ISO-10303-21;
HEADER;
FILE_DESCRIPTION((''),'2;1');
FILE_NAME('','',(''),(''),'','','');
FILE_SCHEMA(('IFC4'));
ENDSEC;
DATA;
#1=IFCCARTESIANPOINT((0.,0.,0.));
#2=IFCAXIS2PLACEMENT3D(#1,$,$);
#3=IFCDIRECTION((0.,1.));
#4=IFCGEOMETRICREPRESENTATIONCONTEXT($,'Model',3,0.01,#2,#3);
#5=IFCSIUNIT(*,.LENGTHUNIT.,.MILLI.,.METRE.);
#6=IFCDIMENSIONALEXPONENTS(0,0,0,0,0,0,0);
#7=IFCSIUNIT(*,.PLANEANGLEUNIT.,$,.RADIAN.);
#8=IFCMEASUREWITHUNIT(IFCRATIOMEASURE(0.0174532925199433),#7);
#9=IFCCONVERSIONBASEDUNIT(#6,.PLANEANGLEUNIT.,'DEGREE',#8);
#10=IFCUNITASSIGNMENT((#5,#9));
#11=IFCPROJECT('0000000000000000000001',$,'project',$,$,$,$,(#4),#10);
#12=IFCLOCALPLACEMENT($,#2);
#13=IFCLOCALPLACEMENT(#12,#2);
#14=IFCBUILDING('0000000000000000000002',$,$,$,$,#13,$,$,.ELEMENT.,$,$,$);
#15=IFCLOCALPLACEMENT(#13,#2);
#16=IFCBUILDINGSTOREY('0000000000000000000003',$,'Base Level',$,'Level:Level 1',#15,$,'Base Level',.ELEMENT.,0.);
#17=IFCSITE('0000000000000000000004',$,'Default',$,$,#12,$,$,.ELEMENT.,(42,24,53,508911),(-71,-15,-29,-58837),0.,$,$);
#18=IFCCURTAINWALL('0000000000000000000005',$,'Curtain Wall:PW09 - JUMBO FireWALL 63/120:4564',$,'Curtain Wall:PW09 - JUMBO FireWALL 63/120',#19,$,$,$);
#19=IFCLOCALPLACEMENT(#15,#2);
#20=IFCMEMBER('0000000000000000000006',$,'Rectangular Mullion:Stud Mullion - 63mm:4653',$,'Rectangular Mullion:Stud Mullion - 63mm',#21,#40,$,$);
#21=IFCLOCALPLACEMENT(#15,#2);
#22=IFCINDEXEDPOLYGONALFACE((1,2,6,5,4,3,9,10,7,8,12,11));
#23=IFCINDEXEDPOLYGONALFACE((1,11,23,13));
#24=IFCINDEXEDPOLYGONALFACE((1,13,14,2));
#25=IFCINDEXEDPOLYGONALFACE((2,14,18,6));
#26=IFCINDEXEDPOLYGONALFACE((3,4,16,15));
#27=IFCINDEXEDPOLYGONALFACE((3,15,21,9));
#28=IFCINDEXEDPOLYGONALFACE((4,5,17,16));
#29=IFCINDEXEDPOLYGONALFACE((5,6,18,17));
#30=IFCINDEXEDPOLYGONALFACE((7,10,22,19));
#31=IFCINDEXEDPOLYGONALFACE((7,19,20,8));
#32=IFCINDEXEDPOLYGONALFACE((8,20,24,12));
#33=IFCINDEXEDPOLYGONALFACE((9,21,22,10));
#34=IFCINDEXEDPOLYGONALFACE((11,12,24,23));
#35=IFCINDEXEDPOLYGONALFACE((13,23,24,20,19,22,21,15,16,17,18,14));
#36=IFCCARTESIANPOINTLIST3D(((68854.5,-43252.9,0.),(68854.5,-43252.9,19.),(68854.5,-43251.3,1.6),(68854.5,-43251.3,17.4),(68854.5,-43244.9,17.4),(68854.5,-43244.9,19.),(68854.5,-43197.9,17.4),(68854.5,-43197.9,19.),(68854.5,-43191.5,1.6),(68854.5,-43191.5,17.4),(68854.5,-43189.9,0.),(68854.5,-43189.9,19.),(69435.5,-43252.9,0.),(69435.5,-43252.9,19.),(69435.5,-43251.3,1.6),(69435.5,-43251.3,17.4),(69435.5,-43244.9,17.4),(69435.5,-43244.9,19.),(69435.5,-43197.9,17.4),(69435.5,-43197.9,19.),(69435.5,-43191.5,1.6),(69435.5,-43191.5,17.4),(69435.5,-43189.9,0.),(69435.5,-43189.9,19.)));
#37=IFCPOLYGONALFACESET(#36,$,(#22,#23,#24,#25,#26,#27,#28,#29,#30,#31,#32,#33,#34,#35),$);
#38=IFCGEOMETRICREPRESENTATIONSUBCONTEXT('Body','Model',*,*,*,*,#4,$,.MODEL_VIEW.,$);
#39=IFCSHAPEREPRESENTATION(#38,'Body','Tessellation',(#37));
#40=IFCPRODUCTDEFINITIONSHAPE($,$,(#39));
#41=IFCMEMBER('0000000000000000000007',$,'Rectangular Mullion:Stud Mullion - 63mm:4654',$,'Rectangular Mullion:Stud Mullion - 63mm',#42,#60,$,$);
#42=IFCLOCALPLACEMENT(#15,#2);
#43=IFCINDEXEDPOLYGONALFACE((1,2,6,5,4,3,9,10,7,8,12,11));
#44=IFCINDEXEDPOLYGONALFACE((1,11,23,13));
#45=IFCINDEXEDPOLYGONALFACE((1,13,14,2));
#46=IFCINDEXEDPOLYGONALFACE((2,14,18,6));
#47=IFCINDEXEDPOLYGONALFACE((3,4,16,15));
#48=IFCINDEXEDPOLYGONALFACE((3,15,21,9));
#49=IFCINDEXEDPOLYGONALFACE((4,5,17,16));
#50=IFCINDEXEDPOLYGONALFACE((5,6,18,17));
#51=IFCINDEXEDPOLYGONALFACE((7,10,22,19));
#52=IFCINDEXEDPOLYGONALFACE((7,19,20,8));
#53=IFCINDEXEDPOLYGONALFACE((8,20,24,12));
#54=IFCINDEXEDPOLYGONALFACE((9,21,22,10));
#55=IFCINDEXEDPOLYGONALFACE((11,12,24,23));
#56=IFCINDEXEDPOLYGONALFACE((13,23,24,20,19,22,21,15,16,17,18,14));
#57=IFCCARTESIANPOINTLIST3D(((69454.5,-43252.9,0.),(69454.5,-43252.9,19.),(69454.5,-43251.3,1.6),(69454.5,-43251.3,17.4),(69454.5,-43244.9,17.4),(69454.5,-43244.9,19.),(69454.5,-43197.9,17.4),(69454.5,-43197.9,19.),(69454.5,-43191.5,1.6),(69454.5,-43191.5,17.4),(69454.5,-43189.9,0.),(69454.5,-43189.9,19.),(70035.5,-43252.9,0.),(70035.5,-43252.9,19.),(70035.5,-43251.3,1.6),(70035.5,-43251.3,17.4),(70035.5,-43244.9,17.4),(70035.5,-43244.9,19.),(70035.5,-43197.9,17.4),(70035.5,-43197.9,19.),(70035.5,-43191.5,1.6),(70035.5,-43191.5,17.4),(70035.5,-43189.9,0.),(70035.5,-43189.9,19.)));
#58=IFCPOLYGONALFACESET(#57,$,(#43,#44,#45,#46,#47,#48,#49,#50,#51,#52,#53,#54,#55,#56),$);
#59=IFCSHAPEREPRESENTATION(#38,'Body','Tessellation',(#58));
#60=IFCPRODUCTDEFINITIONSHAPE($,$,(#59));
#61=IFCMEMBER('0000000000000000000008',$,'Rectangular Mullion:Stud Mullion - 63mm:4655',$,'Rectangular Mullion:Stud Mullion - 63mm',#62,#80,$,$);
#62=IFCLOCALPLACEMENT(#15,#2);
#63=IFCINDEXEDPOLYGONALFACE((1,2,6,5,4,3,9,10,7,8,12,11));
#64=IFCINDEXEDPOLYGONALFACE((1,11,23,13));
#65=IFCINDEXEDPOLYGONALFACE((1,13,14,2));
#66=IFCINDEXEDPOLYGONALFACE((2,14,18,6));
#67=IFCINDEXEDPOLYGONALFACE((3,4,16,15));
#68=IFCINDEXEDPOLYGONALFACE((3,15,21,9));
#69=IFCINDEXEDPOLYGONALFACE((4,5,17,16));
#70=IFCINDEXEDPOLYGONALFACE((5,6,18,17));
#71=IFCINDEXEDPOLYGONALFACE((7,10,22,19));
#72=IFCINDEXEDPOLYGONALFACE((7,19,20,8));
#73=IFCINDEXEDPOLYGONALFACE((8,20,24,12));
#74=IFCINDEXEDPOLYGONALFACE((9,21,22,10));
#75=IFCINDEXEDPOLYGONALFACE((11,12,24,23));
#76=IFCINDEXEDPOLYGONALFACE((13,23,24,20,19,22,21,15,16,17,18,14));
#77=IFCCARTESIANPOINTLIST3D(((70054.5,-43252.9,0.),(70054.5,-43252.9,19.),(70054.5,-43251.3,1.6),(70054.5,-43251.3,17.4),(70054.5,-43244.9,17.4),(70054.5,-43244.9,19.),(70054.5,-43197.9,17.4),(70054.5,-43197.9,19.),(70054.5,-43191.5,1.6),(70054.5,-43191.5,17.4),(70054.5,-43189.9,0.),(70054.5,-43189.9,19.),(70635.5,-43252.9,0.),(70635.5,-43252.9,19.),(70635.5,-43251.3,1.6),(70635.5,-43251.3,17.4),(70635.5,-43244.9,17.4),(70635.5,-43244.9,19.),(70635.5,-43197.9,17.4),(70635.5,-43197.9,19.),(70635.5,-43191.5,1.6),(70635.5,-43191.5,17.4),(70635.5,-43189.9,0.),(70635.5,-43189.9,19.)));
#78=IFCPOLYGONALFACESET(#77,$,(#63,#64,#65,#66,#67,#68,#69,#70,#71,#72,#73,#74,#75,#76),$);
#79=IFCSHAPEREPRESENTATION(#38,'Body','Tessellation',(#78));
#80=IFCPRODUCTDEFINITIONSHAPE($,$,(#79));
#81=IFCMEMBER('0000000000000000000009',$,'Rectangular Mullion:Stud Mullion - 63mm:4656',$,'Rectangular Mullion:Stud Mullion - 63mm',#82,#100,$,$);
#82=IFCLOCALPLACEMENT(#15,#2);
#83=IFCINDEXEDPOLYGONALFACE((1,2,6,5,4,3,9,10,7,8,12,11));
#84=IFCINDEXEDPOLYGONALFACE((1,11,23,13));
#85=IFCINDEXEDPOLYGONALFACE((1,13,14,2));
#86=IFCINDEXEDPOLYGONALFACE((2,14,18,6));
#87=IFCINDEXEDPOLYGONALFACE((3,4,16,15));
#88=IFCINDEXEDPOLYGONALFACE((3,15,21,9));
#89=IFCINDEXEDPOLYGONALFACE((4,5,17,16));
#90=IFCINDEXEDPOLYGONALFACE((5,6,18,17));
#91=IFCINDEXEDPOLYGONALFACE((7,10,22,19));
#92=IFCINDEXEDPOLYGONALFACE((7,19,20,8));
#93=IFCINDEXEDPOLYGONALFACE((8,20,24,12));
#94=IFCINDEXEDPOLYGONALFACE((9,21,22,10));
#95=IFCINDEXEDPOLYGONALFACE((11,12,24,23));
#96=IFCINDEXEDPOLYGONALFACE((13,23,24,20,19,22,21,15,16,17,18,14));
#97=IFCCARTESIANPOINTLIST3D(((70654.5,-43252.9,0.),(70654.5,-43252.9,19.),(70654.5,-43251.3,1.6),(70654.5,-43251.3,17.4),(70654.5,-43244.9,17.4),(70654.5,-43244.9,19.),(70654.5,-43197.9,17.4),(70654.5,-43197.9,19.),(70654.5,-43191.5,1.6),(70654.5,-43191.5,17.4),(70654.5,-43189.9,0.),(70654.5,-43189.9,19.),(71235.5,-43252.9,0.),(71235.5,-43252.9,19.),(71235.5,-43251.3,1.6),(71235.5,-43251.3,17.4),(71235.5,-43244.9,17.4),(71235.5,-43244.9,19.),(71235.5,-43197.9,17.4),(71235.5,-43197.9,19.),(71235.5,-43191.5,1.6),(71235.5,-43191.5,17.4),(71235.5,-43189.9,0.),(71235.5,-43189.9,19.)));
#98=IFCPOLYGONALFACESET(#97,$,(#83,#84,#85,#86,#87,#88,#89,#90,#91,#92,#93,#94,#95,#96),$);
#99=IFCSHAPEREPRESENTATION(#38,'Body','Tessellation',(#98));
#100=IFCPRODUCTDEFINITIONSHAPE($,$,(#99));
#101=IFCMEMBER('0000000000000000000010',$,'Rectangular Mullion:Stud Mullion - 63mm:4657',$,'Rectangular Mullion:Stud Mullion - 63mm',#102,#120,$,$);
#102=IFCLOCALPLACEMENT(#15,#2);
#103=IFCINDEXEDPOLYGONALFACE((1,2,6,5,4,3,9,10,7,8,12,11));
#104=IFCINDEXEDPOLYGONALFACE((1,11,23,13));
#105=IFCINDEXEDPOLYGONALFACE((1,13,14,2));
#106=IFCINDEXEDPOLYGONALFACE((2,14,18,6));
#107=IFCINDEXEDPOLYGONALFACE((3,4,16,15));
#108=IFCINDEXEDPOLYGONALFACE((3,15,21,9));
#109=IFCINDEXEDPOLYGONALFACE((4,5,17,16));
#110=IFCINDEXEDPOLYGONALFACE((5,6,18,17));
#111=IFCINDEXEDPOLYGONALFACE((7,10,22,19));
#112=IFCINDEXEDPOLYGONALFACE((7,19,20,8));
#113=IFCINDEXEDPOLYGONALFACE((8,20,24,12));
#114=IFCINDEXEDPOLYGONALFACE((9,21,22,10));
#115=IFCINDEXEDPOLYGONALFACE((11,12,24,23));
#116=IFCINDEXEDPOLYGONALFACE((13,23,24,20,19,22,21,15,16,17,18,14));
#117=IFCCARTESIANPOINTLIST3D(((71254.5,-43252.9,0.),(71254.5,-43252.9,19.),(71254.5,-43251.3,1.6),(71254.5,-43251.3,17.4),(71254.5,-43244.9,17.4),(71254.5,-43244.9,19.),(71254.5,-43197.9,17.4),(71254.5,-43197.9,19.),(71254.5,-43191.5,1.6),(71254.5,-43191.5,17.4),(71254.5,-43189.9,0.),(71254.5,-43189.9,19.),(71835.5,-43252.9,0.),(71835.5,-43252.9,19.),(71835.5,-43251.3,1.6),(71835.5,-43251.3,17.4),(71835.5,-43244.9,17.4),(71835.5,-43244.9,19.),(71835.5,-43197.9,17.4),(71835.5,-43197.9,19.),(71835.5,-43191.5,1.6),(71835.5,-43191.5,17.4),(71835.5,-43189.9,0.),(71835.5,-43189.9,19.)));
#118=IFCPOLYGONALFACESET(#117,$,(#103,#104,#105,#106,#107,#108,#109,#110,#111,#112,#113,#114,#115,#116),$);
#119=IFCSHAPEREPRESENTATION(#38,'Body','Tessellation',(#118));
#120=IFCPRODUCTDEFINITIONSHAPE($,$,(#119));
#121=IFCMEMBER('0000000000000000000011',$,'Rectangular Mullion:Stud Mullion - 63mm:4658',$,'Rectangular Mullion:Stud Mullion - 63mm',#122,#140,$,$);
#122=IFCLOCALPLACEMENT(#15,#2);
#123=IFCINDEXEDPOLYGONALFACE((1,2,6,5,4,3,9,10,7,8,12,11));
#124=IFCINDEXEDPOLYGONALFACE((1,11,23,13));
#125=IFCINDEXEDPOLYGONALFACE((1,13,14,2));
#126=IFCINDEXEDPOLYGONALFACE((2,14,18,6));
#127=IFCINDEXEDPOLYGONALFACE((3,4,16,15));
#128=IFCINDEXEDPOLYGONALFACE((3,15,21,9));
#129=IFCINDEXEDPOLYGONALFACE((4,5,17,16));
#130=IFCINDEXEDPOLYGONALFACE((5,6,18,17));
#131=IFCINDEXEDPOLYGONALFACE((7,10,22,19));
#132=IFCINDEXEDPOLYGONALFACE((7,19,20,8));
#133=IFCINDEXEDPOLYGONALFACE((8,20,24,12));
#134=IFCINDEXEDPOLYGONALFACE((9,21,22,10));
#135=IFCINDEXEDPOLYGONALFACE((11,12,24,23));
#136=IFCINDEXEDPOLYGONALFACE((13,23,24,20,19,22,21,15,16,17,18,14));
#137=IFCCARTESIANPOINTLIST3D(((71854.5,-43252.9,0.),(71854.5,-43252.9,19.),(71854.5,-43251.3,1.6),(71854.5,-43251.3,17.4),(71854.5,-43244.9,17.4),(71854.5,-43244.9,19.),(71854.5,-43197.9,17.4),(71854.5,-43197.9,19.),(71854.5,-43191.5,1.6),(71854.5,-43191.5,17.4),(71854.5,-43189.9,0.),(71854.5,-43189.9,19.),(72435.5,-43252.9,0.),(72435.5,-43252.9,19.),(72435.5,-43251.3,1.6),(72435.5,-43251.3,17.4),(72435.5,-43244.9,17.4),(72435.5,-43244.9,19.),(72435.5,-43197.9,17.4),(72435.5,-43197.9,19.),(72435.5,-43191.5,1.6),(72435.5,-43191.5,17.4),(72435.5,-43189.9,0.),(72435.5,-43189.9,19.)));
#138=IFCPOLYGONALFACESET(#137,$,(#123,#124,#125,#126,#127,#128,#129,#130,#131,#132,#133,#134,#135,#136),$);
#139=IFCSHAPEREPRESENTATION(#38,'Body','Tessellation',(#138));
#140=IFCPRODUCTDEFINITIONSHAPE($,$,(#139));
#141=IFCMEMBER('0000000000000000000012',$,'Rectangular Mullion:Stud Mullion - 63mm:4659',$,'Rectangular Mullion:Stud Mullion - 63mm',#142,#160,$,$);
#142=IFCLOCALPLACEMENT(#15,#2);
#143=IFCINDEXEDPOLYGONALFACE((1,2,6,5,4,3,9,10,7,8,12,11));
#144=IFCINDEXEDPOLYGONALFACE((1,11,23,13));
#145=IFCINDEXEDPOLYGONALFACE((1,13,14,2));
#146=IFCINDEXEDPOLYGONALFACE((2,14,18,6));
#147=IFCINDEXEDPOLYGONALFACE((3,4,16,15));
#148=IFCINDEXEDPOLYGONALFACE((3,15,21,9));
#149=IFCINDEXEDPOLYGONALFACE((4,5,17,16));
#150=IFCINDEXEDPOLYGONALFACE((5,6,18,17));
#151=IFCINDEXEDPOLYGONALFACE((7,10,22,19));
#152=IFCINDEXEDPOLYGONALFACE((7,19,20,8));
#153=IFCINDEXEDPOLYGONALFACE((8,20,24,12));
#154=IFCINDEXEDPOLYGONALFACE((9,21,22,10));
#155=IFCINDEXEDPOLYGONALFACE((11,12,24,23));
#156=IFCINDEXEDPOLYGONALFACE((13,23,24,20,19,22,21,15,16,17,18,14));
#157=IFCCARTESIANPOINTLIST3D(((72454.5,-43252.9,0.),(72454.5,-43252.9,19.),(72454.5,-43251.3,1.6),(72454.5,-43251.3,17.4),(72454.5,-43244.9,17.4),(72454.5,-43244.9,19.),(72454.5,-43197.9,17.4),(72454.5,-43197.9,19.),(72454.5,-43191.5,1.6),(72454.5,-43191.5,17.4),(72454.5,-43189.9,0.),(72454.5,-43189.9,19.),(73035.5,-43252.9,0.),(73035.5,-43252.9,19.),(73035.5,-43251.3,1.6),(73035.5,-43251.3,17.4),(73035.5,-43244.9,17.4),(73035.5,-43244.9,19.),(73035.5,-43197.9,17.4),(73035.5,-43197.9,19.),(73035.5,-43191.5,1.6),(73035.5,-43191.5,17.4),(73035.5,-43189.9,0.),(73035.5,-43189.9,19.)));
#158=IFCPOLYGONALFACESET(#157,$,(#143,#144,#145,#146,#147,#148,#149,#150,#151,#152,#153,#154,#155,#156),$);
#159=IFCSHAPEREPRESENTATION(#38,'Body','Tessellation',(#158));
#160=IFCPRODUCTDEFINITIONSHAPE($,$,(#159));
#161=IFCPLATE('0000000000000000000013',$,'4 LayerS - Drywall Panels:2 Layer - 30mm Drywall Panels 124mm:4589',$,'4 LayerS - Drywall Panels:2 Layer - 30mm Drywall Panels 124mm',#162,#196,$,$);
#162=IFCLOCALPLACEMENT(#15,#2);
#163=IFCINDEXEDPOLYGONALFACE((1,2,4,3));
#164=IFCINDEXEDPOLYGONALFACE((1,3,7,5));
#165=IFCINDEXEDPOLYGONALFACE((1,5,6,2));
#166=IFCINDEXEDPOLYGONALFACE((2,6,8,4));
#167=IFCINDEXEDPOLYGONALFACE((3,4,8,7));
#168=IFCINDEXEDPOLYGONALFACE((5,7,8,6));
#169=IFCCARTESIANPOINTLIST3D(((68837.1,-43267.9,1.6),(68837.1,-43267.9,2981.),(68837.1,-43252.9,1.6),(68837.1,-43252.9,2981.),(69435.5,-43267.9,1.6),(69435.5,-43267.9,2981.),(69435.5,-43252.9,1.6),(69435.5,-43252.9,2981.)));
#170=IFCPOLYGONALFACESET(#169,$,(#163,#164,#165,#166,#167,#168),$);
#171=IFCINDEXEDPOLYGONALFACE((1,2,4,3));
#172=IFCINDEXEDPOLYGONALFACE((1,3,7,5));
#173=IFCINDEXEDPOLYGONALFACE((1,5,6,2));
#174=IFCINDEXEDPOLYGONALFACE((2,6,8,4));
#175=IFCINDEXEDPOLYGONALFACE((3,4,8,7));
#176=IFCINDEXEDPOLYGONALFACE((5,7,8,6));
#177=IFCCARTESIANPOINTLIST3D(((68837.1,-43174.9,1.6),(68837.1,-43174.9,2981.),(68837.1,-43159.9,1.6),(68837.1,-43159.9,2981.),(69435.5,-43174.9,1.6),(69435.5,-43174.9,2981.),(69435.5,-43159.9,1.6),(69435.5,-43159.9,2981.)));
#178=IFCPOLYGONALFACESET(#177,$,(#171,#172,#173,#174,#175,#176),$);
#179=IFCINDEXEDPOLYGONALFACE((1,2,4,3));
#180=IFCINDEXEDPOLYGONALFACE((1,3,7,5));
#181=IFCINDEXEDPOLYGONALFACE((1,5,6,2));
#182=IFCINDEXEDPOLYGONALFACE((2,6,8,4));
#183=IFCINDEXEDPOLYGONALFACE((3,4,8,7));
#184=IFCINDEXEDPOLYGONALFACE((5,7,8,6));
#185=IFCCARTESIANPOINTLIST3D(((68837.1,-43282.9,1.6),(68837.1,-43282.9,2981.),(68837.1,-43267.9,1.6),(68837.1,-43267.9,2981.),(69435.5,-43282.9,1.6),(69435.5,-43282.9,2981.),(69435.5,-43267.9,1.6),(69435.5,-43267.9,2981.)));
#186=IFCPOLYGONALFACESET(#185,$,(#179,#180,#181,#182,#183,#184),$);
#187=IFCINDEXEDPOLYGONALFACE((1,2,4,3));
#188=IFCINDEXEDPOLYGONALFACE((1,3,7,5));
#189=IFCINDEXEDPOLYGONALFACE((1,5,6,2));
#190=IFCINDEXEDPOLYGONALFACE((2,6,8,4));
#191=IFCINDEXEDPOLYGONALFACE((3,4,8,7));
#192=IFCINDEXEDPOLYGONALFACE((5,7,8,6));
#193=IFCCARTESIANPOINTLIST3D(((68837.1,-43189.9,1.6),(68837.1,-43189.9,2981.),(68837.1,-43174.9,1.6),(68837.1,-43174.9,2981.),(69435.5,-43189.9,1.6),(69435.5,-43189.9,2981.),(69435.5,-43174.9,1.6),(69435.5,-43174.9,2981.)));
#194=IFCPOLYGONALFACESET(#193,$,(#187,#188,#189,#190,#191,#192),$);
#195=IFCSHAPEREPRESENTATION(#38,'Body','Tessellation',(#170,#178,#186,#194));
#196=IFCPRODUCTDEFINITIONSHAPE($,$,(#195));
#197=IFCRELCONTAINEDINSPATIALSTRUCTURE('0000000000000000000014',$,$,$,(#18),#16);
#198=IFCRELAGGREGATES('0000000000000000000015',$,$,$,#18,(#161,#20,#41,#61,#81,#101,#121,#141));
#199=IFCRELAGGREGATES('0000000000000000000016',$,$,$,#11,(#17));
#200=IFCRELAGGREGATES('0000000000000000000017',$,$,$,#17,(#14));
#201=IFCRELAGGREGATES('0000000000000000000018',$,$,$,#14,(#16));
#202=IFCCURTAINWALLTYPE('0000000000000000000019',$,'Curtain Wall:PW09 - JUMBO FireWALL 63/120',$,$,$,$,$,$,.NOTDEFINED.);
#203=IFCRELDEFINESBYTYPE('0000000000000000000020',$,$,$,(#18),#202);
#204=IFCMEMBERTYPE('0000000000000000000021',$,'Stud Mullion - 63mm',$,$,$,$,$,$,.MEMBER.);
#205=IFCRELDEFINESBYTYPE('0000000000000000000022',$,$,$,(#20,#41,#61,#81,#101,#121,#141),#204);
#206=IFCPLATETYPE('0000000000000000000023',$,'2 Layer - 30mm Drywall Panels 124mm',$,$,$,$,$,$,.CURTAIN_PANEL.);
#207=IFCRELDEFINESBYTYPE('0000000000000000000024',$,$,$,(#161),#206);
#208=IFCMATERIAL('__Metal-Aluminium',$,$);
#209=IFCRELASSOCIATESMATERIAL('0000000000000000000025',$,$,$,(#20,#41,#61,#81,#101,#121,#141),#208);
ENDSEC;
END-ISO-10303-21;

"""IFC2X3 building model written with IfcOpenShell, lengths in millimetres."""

from ifc_helpers import new_model, entity, si_unit, converted_unit, direction, frame, frame_2d, origin, origin_2d_with_axis, place, context, subcontext, project, spatial, polyline, rectangle, outline, extrude, source, transform, mapped, material, type_object, type_shapes, element, aggregate, save


model = new_model("IFC2X3")

# Units and contexts
model_context = context("Model", 3, precision=0.01, world=origin(), true_north=direction((0.0, 1.0)))
body_context = subcontext(model_context, "Body", "Model", "MODEL_VIEW")
ifc_project = project(units=[si_unit("LENGTHUNIT", "METRE", prefix="MILLI"), converted_unit("PLANEANGLEUNIT", "DEGREE", entity("IfcRatioMeasure", 0.0174532925199433), si_unit("PLANEANGLEUNIT", "RADIAN"), dimensions=[0, 0, 0, 0, 0, 0, 0])], contexts=[model_context])

# Site, building, storey
site_placement = place(None, origin())
site = spatial("IfcSite", under=ifc_project, at=site_placement, Name="Default", CompositionType="ELEMENT", RefLatitude=(42, 24, 53, 508911), RefLongitude=(-71, -15, -29, -58837), RefElevation=0.0)
building_placement = place(site_placement, origin())
building = spatial("IfcBuilding", under=site, at=building_placement, CompositionType="ELEMENT")
storey_placement = place(building_placement, origin())
storey = spatial("IfcBuildingStorey", under=building, at=storey_placement, Name="Base Level", ObjectType="Level:Level 1", LongName="Base Level", CompositionType="ELEMENT", Elevation=0.0)

# Curtain wall, members, plate
curtain_wall_type = type_object("IfcCurtainWallType", Name="Curtain Wall:PW09 - JUMBO FireWALL 63/120", PredefinedType="NOTDEFINED")
curtain_wall_placement = place(building_placement, origin())
curtain_wall = element("IfcCurtainWall", 1, at=curtain_wall_placement, inside=storey, type_object=curtain_wall_type, Name="Curtain Wall:PW09 - JUMBO FireWALL 63/120:4564", ObjectType="Curtain Wall:PW09 - JUMBO FireWALL 63/120")
ifc_material = material(Name="__Metal-Aluminium")
member_type_1 = type_object("IfcMemberType", Name="Stud Mullion - 63mm", PredefinedType="MEMBER")
shared_shape_1 = source(origin(), body_context, "Body", "SweptSolid", [
    extrude(outline(polyline([(23.5, -6.6), (31.5, -6.6), (31.5, 12.4), (-31.5, 12.4), (-31.5, -6.6), (-23.5, -6.6), (-23.5, -5.0), (-29.9, -5.0), (-29.9, 10.8), (29.9, 10.8), (29.9, -5.0), (23.5, -5.0), (23.5, -6.6)])), frame((-12.4, 0.0, -581.0), z_axis=(0.0, 0.0, 1.0), x_axis=(0.0, -1.0, 0.0)), (0.0, 0.0, 1.0), 581.0),
])
type_shapes(member_type_1, [shared_shape_1])
member_1_placement = place(building_placement, frame((68854.5, -43221.4, 0.0), z_axis=(-1.0, 0.0, 0.0), x_axis=(0.0, 0.0, -1.0)))
member_1 = element("IfcMember", 2, at=member_1_placement, type_object=member_type_1, material=ifc_material, Name="Rectangular Mullion:Stud Mullion - 63mm:4653", ObjectType="Rectangular Mullion:Stud Mullion - 63mm", context=body_context, shape_type="MappedRepresentation", body=[
    mapped(shared_shape_1, transform((0.0, 0.0, 0.0), scale=1.0)),
])
member_2_placement = place(building_placement, frame((69454.5, -43221.4, 0.0), z_axis=(-1.0, 0.0, 0.0), x_axis=(0.0, 0.0, -1.0)))
member_2 = element("IfcMember", 3, at=member_2_placement, type_object=member_type_1, material=ifc_material, Name="Rectangular Mullion:Stud Mullion - 63mm:4654", ObjectType="Rectangular Mullion:Stud Mullion - 63mm", context=body_context, shape_type="MappedRepresentation", body=[
    mapped(shared_shape_1, transform((0.0, 0.0, 0.0), scale=1.0)),
])
member_3_placement = place(building_placement, frame((70054.5, -43221.4, 0.0), z_axis=(-1.0, 0.0, 0.0), x_axis=(0.0, 0.0, -1.0)))
member_3 = element("IfcMember", 4, at=member_3_placement, type_object=member_type_1, material=ifc_material, Name="Rectangular Mullion:Stud Mullion - 63mm:4655", ObjectType="Rectangular Mullion:Stud Mullion - 63mm", context=body_context, shape_type="MappedRepresentation", body=[
    mapped(shared_shape_1, transform((0.0, 0.0, 0.0), scale=1.0)),
])
member_4_placement = place(building_placement, frame((70654.5, -43221.4, 0.0), z_axis=(-1.0, 0.0, 0.0), x_axis=(0.0, 0.0, -1.0)))
member_4 = element("IfcMember", 5, at=member_4_placement, type_object=member_type_1, material=ifc_material, Name="Rectangular Mullion:Stud Mullion - 63mm:4656", ObjectType="Rectangular Mullion:Stud Mullion - 63mm", context=body_context, shape_type="MappedRepresentation", body=[
    mapped(shared_shape_1, transform((0.0, 0.0, 0.0), scale=1.0)),
])
member_5_placement = place(building_placement, frame((71254.5, -43221.4, 0.0), z_axis=(-1.0, 0.0, 0.0), x_axis=(0.0, 0.0, -1.0)))
member_5 = element("IfcMember", 6, at=member_5_placement, type_object=member_type_1, material=ifc_material, Name="Rectangular Mullion:Stud Mullion - 63mm:4657", ObjectType="Rectangular Mullion:Stud Mullion - 63mm", context=body_context, shape_type="MappedRepresentation", body=[
    mapped(shared_shape_1, transform((0.0, 0.0, 0.0), scale=1.0)),
])
member_6_placement = place(building_placement, frame((71854.5, -43221.4, 0.0), z_axis=(-1.0, 0.0, 0.0), x_axis=(0.0, 0.0, -1.0)))
member_6 = element("IfcMember", 7, at=member_6_placement, type_object=member_type_1, material=ifc_material, Name="Rectangular Mullion:Stud Mullion - 63mm:4658", ObjectType="Rectangular Mullion:Stud Mullion - 63mm", context=body_context, shape_type="MappedRepresentation", body=[
    mapped(shared_shape_1, transform((0.0, 0.0, 0.0), scale=1.0)),
])
member_7_placement = place(building_placement, frame((72454.5, -43221.4, 0.0), z_axis=(-1.0, 0.0, 0.0), x_axis=(0.0, 0.0, -1.0)))
member_7 = element("IfcMember", 8, at=member_7_placement, type_object=member_type_1, material=ifc_material, Name="Rectangular Mullion:Stud Mullion - 63mm:4659", ObjectType="Rectangular Mullion:Stud Mullion - 63mm", context=body_context, shape_type="MappedRepresentation", body=[
    mapped(shared_shape_1, transform((0.0, 0.0, 0.0), scale=1.0)),
])
plate_type = type_object("IfcPlateType", Name="2 Layer - 30mm Drywall Panels 124mm", PredefinedType="CURTAIN_PANEL")
shared_shape_2 = source(origin(), body_context, "Body", "SweptSolid", [
    extrude(rectangle(XDim=15.0, YDim=598.4, at=origin_2d_with_axis()), frame((0.0, -39.0, 0.0), z_axis=(0.0, 0.0, 1.0), x_axis=(0.0, 1.0, 0.0)), (0.0, 0.0, 1.0), 2979.4),
    extrude(rectangle(XDim=15.0, YDim=598.4, at=origin_2d_with_axis()), frame((0.0, 54.0, 0.0), z_axis=(0.0, 0.0, 1.0), x_axis=(0.0, 1.0, 0.0)), (0.0, 0.0, 1.0), 2979.4),
    extrude(rectangle(XDim=598.4, YDim=15.0, at=frame_2d((0.0, 0.0), x_axis=(1.0, 0.0))), frame((0.0, -54.0, 0.0), z_axis=(0.0, 0.0, 1.0), x_axis=(-1.0, 0.0, 0.0)), (0.0, 0.0, 1.0), 2979.4),
    extrude(rectangle(XDim=15.0, YDim=598.4, at=frame_2d((0.0, 0.0), x_axis=(1.0, 0.0))), frame((0.0, 39.0, 0.0), z_axis=(0.0, 0.0, 1.0), x_axis=(0.0, 1.0, 0.0)), (0.0, 0.0, 1.0), 2979.4),
])
type_shapes(plate_type, [shared_shape_2])
plate_1_placement = place(curtain_wall_placement, frame((69136.3, -43221.4, 1.6)))
plate_1 = element("IfcPlate", 9, at=plate_1_placement, type_object=plate_type, Name="4 LayerS - Drywall Panels:2 Layer - 30mm Drywall Panels 124mm:4589", ObjectType="4 LayerS - Drywall Panels:2 Layer - 30mm Drywall Panels 124mm", context=body_context, shape_type="MappedRepresentation", body=[
    mapped(shared_shape_2, transform((0.0, 0.0, 0.0), scale=1.0)),
])
aggregate(curtain_wall, [plate_1, member_1, member_2, member_3, member_4, member_5, member_6, member_7])

save(model, "model.ifc")
